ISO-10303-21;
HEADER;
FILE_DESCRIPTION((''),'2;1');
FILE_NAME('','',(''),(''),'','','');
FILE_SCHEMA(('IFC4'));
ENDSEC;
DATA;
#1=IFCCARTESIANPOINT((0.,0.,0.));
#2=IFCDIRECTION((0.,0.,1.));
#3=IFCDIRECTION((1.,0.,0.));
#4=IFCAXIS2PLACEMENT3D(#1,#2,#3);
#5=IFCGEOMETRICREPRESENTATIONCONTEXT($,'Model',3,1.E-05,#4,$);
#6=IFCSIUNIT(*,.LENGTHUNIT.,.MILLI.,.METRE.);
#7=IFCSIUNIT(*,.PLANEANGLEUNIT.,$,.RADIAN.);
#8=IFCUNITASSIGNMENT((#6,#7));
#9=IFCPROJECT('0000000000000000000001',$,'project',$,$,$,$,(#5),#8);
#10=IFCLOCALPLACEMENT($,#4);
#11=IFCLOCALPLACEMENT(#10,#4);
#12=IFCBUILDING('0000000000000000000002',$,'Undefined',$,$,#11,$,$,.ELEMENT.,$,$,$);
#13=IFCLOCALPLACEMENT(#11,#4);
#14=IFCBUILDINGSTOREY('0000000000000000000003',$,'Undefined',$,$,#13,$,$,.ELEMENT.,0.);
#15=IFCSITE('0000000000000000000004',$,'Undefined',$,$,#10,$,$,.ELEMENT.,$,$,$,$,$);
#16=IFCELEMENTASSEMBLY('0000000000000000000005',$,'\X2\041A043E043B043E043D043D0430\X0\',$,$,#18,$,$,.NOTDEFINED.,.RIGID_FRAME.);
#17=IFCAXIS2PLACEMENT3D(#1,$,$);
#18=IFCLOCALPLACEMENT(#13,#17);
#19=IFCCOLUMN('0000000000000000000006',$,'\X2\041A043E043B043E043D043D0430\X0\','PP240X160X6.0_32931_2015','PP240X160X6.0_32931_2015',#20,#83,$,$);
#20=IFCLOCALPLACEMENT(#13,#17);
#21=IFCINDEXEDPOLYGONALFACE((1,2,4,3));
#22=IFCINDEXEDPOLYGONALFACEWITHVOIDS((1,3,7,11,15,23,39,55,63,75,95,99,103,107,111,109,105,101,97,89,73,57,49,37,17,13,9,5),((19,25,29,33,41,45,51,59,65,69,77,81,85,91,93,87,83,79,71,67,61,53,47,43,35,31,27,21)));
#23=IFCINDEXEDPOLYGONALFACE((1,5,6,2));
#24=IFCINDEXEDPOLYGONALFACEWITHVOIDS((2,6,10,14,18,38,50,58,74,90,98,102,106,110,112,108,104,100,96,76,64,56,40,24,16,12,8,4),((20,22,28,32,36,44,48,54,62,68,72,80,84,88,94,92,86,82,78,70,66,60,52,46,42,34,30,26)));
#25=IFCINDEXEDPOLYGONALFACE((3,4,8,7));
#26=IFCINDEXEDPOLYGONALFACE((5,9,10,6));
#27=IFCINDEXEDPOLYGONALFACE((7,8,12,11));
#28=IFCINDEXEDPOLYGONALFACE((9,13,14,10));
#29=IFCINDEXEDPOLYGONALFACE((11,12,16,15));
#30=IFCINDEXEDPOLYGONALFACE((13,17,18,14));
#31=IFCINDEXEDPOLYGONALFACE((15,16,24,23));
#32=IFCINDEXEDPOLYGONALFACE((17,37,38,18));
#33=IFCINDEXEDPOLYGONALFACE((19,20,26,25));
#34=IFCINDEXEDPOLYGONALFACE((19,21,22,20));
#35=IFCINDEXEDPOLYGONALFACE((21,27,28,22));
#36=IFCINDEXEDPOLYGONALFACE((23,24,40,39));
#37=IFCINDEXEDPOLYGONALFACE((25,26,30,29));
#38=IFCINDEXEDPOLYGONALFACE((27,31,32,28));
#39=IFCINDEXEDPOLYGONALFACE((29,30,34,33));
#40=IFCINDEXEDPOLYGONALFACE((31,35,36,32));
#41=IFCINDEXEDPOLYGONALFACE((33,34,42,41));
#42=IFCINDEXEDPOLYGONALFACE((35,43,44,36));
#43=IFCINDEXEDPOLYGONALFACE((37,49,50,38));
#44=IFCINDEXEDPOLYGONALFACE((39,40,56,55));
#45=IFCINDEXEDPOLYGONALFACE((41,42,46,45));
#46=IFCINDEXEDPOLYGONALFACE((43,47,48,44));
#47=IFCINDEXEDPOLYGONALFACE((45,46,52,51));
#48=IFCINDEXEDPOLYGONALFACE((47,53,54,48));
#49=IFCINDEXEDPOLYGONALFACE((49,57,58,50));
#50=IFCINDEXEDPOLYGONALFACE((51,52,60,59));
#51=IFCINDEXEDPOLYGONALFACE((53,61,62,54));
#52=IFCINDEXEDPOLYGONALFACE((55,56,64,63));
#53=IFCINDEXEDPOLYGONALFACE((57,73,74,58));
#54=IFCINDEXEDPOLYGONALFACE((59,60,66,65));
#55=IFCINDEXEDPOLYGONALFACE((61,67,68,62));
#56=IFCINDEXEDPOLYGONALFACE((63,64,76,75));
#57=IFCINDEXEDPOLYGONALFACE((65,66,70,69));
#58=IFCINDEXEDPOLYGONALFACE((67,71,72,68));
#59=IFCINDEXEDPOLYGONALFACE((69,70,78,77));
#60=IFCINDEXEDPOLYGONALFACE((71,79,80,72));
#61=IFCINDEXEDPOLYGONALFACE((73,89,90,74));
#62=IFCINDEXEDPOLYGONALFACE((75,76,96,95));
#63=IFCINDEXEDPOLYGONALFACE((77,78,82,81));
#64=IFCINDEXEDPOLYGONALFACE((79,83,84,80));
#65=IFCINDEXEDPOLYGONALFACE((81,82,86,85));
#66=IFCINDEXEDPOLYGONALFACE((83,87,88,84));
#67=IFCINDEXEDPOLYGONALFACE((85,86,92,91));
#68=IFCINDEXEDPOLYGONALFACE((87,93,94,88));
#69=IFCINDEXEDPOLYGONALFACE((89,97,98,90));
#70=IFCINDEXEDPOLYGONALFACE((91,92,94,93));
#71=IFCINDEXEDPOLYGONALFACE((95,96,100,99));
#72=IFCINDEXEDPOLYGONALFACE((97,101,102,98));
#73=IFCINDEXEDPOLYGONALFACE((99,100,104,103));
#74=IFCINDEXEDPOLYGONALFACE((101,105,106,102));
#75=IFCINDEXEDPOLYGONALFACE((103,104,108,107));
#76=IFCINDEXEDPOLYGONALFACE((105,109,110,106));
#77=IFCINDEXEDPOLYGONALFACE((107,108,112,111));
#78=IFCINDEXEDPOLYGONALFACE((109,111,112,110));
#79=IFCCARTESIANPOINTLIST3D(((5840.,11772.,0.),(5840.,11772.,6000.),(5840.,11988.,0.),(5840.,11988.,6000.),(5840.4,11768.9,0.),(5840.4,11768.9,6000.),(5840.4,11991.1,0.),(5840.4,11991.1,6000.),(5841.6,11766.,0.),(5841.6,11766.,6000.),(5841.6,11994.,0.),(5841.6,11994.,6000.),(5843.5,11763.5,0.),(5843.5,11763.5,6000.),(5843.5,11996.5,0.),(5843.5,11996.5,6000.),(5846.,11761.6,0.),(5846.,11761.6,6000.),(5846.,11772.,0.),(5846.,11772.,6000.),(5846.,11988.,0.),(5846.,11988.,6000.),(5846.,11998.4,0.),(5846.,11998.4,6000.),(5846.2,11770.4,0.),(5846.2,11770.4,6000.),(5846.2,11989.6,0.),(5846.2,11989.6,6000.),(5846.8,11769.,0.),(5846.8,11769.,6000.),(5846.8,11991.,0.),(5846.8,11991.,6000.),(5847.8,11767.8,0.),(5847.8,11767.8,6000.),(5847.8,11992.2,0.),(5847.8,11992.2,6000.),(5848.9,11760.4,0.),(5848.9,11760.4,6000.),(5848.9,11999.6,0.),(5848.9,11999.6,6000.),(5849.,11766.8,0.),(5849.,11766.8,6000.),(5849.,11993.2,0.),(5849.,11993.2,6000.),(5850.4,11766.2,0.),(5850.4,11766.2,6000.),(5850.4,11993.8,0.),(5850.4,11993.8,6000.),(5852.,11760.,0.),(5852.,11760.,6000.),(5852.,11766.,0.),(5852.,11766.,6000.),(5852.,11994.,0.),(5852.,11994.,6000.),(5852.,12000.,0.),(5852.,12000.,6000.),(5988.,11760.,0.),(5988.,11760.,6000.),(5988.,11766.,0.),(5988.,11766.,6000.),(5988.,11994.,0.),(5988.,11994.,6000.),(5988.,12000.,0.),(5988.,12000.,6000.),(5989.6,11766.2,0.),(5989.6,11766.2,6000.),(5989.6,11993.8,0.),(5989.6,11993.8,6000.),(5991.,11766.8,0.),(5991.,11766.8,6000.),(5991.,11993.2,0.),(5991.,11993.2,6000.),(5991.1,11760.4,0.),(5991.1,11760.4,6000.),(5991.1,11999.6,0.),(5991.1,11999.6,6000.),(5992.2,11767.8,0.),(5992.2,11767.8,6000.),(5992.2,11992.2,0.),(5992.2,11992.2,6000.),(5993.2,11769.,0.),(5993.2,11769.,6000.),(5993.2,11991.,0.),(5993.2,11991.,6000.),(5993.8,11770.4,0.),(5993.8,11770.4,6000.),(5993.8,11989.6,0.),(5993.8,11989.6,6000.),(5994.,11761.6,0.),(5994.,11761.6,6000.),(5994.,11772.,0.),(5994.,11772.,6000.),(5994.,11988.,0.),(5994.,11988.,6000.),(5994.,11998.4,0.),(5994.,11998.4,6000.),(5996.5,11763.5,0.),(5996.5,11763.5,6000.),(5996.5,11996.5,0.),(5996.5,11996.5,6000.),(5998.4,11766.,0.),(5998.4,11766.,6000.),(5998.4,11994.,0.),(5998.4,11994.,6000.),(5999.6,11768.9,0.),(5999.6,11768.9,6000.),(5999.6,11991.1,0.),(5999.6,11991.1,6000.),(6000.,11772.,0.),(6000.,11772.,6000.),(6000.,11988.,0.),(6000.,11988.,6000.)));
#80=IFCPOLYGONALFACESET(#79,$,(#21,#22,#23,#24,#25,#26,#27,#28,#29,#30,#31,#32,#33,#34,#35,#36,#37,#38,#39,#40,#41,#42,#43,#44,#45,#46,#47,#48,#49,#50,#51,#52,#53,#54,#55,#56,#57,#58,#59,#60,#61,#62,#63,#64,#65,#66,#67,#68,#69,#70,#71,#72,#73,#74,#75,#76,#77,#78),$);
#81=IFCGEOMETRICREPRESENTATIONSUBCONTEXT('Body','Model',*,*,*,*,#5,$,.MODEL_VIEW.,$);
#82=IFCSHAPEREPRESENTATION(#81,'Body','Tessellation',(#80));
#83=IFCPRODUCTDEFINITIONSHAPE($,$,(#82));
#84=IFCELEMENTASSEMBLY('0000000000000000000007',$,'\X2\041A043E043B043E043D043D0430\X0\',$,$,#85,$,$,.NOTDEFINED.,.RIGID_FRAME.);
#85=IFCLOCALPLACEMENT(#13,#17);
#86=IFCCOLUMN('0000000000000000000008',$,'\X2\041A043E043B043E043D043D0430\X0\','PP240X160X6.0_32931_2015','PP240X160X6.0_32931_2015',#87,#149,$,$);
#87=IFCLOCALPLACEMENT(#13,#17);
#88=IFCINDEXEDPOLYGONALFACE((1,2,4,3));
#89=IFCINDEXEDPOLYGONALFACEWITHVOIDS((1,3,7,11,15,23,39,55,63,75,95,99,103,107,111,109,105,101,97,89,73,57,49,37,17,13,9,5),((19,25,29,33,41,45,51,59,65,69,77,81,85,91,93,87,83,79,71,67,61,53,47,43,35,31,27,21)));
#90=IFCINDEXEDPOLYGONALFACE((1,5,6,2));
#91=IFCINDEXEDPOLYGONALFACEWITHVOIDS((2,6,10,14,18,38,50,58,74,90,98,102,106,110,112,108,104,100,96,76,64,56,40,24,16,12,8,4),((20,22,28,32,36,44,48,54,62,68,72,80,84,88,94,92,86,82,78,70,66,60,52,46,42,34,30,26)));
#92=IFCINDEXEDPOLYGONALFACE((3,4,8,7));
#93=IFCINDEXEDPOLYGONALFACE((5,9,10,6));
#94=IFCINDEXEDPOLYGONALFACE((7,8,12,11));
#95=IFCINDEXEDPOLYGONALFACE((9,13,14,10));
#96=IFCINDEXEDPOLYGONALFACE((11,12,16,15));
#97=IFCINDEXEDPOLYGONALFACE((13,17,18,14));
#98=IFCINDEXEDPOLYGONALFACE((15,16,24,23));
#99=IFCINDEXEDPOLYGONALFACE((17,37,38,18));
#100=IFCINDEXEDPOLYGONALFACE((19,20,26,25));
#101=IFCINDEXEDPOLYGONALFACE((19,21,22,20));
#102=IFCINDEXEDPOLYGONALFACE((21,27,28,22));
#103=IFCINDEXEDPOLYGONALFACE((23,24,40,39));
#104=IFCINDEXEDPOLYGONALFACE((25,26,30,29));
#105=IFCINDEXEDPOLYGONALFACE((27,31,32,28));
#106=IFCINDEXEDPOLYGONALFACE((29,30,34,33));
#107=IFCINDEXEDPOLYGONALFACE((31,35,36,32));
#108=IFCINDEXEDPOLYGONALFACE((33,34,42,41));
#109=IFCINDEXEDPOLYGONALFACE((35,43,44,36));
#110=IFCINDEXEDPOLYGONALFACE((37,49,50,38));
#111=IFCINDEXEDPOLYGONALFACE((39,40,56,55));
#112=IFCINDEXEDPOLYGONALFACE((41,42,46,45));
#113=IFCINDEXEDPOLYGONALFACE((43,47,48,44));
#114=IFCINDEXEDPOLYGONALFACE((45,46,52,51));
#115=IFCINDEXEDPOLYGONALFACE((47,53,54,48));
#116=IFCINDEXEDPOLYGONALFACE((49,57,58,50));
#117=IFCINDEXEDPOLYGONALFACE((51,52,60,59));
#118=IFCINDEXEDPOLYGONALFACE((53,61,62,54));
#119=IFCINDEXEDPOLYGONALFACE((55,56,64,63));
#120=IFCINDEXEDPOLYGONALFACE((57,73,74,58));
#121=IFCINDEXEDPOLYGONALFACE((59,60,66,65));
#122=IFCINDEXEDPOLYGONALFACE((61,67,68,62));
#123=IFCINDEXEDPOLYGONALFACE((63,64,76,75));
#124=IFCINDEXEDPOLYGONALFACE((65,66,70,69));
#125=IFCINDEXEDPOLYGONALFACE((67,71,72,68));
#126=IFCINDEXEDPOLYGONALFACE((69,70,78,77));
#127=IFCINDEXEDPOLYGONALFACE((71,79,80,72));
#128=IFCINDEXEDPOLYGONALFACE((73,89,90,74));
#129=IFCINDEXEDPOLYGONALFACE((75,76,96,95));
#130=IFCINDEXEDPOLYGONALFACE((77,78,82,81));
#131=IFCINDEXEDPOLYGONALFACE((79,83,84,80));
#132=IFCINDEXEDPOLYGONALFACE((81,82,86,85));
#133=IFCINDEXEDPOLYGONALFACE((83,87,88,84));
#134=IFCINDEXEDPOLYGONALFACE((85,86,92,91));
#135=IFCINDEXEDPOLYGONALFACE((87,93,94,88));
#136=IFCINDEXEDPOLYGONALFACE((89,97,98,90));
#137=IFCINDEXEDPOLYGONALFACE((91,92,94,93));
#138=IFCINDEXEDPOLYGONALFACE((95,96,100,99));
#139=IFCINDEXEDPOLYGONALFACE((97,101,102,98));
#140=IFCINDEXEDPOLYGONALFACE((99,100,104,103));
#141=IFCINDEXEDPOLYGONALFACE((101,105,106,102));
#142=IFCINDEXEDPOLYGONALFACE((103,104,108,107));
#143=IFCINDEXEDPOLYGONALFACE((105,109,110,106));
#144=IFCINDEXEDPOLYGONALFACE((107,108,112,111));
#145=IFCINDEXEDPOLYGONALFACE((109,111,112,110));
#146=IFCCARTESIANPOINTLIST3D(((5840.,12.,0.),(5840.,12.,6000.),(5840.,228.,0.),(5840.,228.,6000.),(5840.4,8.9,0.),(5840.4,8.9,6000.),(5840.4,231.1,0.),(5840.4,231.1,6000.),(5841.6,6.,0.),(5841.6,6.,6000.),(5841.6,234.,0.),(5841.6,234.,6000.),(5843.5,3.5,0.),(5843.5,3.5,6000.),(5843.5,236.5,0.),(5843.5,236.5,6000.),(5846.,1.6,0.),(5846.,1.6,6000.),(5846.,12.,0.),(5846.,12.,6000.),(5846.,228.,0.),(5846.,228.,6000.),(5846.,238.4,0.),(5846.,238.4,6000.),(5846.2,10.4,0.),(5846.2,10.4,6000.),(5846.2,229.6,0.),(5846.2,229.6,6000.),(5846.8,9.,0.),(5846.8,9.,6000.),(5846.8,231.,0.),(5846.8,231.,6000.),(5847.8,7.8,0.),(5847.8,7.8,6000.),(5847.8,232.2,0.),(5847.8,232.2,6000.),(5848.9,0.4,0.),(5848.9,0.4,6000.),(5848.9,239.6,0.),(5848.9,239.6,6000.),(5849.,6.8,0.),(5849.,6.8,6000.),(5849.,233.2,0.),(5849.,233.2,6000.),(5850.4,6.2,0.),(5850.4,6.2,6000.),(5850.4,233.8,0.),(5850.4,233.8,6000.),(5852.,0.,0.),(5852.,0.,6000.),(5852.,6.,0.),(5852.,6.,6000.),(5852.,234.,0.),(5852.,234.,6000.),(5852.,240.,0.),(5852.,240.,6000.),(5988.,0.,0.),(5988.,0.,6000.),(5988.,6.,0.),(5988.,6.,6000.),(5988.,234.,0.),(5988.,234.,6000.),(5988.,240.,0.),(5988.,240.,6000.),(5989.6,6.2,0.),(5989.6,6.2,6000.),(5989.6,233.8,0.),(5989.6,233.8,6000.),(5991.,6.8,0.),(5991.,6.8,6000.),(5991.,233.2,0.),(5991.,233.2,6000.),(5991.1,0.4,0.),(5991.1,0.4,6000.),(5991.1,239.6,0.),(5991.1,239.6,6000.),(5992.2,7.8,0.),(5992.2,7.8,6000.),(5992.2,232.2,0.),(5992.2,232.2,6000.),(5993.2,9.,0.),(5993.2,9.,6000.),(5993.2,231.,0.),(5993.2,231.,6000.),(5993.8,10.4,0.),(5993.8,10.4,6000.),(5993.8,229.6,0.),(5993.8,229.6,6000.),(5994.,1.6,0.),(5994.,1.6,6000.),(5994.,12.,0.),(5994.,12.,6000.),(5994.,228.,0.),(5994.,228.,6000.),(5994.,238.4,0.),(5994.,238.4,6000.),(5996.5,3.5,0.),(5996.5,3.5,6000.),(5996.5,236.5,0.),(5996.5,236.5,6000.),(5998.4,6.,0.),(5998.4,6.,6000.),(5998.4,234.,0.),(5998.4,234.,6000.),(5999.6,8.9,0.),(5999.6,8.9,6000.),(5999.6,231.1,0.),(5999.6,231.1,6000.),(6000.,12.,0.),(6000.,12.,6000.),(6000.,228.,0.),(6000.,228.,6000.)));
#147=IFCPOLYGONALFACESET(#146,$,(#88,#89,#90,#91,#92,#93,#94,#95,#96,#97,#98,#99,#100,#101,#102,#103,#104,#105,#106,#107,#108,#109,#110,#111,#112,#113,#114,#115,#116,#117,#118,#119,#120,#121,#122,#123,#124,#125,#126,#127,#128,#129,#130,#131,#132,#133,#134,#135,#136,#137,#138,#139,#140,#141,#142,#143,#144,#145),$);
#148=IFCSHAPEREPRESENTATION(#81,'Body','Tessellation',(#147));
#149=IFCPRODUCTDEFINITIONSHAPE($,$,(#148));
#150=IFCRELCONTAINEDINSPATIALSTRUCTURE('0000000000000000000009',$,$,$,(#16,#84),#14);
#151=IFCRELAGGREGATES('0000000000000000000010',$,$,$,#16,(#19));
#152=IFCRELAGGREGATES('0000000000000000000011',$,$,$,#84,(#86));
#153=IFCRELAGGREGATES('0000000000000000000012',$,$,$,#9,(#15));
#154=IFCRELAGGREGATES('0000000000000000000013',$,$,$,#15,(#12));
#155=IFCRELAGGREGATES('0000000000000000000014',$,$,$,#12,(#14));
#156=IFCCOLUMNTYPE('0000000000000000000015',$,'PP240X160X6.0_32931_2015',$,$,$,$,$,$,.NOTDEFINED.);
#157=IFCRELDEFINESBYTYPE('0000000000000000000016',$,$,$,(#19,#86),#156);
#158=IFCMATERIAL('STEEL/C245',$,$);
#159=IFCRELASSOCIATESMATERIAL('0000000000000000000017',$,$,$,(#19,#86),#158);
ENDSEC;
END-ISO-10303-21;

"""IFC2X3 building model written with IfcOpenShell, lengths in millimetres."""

from ifc_helpers import new_model, si_unit, frame, origin_with_axes, origin_2d_with_axis, place, context, subcontext, project, spatial, hollow_rectangle, extrude, material, type_object, element, aggregate, save


model = new_model("IFC2X3")

# Units and contexts
model_context = context("Model", 3, precision=1e-05, world=origin_with_axes())
body_context = subcontext(model_context, "Body", "Model", "MODEL_VIEW")
ifc_project = project(units=[si_unit("LENGTHUNIT", "METRE", prefix="MILLI"), si_unit("PLANEANGLEUNIT", "RADIAN")], contexts=[model_context])

# Site, building, storey
site_placement = place(None, origin_with_axes())
site = spatial("IfcSite", under=ifc_project, at=site_placement, Name="Undefined", CompositionType="ELEMENT")
building_placement = place(site_placement, origin_with_axes())
building = spatial("IfcBuilding", under=site, at=building_placement, Name="Undefined", CompositionType="ELEMENT")
storey_placement = place(building_placement, origin_with_axes())
storey = spatial("IfcBuildingStorey", under=building, at=storey_placement, Name="Undefined", CompositionType="ELEMENT", Elevation=0.0)

# Element assemblies, columns
assembly_1_placement = place(storey_placement, origin_with_axes())
assembly_1 = element("IfcElementAssembly", 1, at=assembly_1_placement, inside=storey, Name="Колонна", AssemblyPlace="NOTDEFINED", PredefinedType="RIGID_FRAME")
ifc_material = material(Name="STEEL/C245")
column_type = type_object("IfcColumnType", Name="PP240X160X6.0_32931_2015", PredefinedType="NOTDEFINED")
column_1_placement = place(assembly_1_placement, frame((5920.0, 11880.0, 0.0), z_axis=(0.0, 0.0, 1.0), x_axis=(0.0, -1.0, 0.0)))
column_1 = element("IfcColumn", 2, at=column_1_placement, type_object=column_type, material=ifc_material, Name="Колонна", Description="PP240X160X6.0_32931_2015", ObjectType="PP240X160X6.0_32931_2015", context=body_context, shape_type="SweptSolid", body=[
    extrude(hollow_rectangle(XDim=160.0, YDim=240.0, WallThickness=6.0, InnerFilletRadius=6.0, OuterFilletRadius=12.0, at=origin_2d_with_axis()), frame((0.0, 0.0, 6000.0), z_axis=(0.0, 0.0, -1.0), x_axis=(0.0, 1.0, 0.0)), (0.0, 0.0, 1.0), 6000.0),
])
aggregate(assembly_1, [column_1])
assembly_2_placement = place(storey_placement, origin_with_axes())
assembly_2 = element("IfcElementAssembly", 3, at=assembly_2_placement, inside=storey, Name="Колонна", AssemblyPlace="NOTDEFINED", PredefinedType="RIGID_FRAME")
column_2_placement = place(assembly_2_placement, frame((5920.0, 120.0, 0.0), z_axis=(0.0, 0.0, 1.0), x_axis=(0.0, 1.0, 0.0)))
column_2 = element("IfcColumn", 4, at=column_2_placement, type_object=column_type, material=ifc_material, Name="Колонна", Description="PP240X160X6.0_32931_2015", ObjectType="PP240X160X6.0_32931_2015", context=body_context, shape_type="SweptSolid", body=[
    extrude(hollow_rectangle(XDim=160.0, YDim=240.0, WallThickness=6.0, InnerFilletRadius=6.0, OuterFilletRadius=12.0, at=origin_2d_with_axis()), frame((0.0, 0.0, 6000.0), z_axis=(0.0, 0.0, -1.0), x_axis=(0.0, 1.0, 0.0)), (0.0, 0.0, 1.0), 6000.0),
])
aggregate(assembly_2, [column_2])

save(model, "model.ifc")
